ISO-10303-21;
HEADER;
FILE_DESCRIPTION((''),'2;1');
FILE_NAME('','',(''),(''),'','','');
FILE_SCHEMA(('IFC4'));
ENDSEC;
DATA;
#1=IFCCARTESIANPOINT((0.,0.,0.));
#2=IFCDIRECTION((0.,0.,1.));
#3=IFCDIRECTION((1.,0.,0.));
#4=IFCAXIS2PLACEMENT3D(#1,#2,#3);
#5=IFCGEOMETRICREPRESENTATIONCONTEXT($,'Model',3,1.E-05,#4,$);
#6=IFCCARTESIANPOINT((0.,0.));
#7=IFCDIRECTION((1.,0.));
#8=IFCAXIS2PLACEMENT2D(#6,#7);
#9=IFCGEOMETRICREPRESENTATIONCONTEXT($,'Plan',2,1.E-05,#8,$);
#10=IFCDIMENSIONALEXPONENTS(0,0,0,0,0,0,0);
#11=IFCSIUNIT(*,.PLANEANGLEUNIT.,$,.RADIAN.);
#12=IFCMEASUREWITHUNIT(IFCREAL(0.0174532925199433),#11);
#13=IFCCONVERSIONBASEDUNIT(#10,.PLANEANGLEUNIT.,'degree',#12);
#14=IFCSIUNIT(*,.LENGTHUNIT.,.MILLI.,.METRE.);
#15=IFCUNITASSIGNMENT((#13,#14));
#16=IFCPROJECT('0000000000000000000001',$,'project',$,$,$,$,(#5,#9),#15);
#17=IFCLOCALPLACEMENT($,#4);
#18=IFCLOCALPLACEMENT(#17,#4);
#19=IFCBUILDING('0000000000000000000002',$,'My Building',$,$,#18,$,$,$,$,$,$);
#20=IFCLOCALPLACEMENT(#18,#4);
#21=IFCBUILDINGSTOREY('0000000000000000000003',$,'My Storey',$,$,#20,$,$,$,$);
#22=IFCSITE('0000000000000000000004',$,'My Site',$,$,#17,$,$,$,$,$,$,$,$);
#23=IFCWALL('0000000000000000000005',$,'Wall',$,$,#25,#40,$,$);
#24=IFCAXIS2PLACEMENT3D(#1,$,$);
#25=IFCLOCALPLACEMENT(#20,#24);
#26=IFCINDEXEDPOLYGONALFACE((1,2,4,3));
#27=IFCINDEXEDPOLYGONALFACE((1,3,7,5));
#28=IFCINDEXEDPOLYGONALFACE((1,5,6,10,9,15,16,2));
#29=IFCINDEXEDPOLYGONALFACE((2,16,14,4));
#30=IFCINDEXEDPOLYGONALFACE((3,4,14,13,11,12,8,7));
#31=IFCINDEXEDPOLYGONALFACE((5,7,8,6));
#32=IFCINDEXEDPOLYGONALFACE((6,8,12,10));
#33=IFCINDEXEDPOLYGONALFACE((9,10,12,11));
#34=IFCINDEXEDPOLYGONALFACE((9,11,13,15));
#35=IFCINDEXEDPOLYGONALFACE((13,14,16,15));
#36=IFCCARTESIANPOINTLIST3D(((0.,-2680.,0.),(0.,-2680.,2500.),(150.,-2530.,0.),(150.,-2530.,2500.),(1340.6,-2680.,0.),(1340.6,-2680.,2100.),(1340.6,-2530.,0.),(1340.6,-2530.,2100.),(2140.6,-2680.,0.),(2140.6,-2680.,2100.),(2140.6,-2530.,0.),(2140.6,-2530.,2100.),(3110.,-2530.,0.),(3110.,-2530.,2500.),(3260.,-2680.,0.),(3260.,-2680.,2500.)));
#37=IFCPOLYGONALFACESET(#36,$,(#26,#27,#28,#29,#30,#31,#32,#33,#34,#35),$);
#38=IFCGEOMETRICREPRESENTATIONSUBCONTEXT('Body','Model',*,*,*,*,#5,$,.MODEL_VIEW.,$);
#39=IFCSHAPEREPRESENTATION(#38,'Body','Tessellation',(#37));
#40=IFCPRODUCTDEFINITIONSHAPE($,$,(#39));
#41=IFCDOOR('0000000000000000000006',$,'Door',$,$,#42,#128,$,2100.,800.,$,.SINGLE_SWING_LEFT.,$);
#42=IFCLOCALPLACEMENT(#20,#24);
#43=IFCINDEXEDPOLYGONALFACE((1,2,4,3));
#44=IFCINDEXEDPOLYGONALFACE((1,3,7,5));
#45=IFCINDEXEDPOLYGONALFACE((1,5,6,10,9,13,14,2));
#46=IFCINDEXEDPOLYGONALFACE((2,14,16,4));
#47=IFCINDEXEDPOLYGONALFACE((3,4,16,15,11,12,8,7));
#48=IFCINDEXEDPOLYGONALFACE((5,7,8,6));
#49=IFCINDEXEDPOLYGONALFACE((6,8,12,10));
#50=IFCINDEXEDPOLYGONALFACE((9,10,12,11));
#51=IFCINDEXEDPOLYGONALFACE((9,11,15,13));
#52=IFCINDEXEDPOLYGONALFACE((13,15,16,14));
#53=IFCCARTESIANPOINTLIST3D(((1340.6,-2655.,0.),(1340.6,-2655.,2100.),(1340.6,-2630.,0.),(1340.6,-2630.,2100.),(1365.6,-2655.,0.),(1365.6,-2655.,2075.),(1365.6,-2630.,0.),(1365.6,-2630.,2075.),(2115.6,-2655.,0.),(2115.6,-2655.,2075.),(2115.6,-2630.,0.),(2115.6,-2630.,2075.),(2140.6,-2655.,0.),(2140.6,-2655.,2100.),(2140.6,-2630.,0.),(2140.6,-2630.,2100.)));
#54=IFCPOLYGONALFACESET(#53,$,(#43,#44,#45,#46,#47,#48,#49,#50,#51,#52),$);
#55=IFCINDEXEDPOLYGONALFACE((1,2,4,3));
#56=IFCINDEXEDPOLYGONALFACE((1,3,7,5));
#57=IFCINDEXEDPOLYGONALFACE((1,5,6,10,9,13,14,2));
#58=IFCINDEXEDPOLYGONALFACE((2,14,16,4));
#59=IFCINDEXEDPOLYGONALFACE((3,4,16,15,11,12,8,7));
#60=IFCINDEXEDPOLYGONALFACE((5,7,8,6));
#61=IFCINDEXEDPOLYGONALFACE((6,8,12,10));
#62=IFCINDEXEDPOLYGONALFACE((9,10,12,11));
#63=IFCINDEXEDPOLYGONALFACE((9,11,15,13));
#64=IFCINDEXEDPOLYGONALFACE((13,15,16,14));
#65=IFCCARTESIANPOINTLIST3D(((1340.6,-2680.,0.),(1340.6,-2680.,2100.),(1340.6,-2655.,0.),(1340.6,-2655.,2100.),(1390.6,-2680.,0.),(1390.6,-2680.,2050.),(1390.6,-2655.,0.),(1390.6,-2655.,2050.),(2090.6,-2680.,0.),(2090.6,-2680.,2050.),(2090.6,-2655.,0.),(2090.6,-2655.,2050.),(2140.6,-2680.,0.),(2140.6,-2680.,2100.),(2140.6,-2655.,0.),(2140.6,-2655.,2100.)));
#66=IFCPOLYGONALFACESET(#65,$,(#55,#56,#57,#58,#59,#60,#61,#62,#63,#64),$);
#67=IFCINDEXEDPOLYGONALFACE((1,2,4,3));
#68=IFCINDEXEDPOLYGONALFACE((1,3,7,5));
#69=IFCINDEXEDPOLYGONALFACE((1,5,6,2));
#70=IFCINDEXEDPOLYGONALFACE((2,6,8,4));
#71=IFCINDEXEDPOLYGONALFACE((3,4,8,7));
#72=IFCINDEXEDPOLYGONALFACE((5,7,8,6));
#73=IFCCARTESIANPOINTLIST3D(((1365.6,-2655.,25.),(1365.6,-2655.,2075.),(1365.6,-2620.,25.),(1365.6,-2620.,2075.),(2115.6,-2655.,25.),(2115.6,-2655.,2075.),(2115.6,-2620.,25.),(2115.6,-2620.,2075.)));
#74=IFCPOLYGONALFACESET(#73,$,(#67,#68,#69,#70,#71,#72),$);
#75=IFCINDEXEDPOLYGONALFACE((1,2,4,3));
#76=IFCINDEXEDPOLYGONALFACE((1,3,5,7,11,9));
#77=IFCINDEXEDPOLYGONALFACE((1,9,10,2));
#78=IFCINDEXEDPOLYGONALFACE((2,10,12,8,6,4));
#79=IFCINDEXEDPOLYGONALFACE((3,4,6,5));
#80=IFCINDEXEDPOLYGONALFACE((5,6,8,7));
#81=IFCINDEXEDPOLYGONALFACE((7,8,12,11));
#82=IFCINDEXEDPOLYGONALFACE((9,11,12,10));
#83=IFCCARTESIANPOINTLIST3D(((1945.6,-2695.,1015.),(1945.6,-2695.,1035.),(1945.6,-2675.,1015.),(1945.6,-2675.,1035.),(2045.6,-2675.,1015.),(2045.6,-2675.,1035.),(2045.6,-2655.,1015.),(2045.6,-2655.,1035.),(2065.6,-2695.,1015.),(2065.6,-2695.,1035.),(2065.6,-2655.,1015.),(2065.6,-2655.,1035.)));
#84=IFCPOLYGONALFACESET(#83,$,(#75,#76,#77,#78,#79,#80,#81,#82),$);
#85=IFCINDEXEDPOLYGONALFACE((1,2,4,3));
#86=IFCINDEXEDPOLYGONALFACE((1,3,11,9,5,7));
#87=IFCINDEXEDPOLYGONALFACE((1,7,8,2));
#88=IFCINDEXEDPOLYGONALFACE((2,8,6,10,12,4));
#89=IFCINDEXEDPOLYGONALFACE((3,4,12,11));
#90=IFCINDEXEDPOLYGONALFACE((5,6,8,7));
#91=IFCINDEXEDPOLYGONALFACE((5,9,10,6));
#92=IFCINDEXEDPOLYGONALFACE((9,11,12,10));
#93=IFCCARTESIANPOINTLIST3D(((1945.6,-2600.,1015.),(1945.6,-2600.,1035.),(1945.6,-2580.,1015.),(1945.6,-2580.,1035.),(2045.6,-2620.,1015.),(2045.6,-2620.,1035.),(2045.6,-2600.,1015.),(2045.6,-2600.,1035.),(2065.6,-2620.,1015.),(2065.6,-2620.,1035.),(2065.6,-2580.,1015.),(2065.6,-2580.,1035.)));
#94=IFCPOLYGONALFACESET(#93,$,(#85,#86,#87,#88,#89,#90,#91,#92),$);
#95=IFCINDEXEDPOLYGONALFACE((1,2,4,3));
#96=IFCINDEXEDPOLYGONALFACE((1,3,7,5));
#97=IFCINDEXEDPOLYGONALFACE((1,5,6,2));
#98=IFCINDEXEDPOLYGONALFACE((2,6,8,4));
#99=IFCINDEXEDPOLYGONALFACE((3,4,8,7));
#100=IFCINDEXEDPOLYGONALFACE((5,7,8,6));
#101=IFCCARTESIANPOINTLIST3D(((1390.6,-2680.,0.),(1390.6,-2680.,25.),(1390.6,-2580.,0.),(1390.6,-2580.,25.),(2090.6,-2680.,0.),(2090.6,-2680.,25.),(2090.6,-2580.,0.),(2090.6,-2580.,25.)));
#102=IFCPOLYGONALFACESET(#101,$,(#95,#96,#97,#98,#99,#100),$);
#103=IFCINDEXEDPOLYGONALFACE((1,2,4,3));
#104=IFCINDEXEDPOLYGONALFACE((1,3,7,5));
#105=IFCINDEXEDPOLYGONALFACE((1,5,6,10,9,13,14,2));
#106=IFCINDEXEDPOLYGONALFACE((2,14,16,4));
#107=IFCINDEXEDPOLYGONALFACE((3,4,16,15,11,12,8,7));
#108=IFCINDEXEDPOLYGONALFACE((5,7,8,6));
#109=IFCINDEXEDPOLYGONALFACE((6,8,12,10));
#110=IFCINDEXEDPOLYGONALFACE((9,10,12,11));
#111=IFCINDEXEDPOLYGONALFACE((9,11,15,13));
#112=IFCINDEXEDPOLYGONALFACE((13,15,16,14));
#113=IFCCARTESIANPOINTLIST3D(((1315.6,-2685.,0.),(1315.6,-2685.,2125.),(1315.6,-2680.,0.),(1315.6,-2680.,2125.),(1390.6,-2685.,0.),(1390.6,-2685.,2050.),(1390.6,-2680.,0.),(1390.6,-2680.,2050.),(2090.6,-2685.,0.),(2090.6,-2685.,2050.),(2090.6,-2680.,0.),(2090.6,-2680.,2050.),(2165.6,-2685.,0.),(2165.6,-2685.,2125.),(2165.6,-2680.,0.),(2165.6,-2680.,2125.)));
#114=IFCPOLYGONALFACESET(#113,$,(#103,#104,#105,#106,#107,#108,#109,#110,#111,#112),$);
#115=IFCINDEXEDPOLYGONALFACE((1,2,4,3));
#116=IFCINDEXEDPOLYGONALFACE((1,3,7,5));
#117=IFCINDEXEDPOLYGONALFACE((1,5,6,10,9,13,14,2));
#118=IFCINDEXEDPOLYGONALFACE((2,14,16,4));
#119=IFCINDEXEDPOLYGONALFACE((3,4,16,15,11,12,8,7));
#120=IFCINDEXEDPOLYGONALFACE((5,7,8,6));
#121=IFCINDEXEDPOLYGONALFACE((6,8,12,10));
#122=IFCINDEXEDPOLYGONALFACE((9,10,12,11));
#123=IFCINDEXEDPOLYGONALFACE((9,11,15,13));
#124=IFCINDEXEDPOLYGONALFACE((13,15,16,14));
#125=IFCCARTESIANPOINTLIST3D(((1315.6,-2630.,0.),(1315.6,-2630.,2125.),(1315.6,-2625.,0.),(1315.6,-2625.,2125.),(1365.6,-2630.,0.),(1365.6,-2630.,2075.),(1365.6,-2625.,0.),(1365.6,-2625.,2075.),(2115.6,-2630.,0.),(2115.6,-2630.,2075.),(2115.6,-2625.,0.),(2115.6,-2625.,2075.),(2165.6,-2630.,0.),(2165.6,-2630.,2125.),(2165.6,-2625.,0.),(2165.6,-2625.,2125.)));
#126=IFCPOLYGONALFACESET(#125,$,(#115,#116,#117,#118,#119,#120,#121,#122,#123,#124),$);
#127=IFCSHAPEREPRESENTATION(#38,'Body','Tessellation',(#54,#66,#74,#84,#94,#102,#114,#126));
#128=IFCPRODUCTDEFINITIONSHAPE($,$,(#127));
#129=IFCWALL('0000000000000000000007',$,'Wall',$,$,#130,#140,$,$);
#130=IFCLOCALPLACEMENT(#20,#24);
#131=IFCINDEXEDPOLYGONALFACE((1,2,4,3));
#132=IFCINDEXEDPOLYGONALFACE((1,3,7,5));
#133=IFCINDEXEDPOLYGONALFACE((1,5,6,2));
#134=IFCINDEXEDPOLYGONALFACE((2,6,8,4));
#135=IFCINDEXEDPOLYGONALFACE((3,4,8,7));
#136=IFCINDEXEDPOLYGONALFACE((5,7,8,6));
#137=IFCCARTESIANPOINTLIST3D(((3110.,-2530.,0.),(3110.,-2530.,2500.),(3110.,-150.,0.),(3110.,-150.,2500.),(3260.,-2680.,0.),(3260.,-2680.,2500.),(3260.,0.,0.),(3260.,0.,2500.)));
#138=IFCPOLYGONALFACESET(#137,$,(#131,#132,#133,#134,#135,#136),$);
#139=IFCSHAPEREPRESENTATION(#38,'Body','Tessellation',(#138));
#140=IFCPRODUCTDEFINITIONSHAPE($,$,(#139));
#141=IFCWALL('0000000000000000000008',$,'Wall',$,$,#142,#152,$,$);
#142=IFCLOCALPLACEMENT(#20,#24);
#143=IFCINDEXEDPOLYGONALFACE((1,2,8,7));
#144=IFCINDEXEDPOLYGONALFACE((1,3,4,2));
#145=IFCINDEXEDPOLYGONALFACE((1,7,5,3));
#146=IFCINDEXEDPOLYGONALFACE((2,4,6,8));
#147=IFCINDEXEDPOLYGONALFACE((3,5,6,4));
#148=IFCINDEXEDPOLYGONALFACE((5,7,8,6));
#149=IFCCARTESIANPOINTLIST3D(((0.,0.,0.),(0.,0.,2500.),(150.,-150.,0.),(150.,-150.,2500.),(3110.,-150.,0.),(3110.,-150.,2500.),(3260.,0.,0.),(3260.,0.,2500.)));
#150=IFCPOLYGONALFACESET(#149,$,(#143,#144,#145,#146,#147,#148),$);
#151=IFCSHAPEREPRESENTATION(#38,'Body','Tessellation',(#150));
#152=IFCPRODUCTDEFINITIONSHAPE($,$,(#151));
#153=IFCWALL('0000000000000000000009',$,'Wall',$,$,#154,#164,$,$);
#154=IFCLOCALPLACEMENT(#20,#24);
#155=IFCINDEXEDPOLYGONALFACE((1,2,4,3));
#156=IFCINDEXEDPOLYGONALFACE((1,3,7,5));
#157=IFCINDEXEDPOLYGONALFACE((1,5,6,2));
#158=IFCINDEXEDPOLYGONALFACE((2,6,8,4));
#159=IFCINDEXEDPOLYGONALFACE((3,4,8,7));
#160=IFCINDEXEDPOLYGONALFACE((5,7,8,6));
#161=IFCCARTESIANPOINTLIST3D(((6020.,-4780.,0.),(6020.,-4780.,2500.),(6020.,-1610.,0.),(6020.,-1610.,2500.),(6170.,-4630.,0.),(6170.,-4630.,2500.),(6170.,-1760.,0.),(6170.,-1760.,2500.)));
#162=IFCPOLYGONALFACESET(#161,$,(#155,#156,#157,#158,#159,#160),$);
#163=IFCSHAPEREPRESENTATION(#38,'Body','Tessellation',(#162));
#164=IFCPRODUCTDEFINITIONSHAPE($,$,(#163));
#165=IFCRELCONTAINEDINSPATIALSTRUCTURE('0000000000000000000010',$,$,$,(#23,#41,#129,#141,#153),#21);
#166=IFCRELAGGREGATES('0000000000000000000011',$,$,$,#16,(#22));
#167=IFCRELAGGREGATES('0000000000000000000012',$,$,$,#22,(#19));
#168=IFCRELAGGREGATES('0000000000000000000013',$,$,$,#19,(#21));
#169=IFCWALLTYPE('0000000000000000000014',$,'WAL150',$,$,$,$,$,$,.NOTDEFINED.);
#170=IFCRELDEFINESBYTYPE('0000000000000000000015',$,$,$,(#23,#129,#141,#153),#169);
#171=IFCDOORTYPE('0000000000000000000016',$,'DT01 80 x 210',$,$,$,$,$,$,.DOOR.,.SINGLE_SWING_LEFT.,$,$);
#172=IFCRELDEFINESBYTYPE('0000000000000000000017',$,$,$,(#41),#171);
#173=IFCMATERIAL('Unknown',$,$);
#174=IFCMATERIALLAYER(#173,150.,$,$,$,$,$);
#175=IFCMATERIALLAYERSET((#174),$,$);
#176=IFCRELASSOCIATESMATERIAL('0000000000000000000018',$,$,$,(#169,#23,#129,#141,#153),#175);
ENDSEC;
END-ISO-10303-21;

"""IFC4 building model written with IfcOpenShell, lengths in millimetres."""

from ifc_helpers import new_model, entity, si_unit, converted_unit, frame, origin_with_axes, origin_2d_with_axis, place, context, subcontext, project, spatial, line, indexed_curve, outline, extrude, shape, source, transform, mapped, material, layer, layer_set, layer_usage, type_object, type_shapes, element, fill, save


model = new_model("IFC4")

# Units and contexts
model_context = context("Model", 3, precision=1e-05, world=origin_with_axes())
plan_context = context("Plan", 2, precision=1e-05, world=origin_2d_with_axis())
body_context_1 = subcontext(model_context, "Body", "Model", "MODEL_VIEW")
body_context_2 = subcontext(plan_context, "Body", "Plan", "PLAN_VIEW")
ifc_project = project(units=[converted_unit("PLANEANGLEUNIT", "degree", entity("IfcReal", 0.0174532925199433), si_unit("PLANEANGLEUNIT", "RADIAN"), dimensions=[0, 0, 0, 0, 0, 0, 0]), si_unit("LENGTHUNIT", "METRE", prefix="MILLI")], contexts=[model_context, plan_context])

# Site, building, storey
site_placement = place(None, origin_with_axes())
site = spatial("IfcSite", under=ifc_project, at=site_placement, Name="My Site")
building_placement = place(site_placement, origin_with_axes())
building = spatial("IfcBuilding", under=site, at=building_placement, Name="My Building")
storey_placement = place(building_placement, origin_with_axes())
storey = spatial("IfcBuildingStorey", under=building, at=storey_placement, Name="My Storey")

# Shared definitions
ifc_material = material(Name="Unknown")

# Shared definitions
ifc_layer_1 = layer(ifc_material, 150.0)
ifc_layer_set_1 = layer_set([ifc_layer_1])
wall_type_1 = type_object("IfcWallType", Name="WAL150", PredefinedType="NOTDEFINED", material=ifc_layer_set_1)

# Wall, opening, door
ifc_layer_usage_1 = layer_usage(ifc_layer_set_1, "AXIS2", "POSITIVE", 0.0)
wall_1_placement = place(storey_placement, frame((0.0, -2680.0, 0.0), z_axis=(0.0, 0.0, 1.0), x_axis=(1.0, 0.0, 0.0)))
wall_1 = element("IfcWall", 1, at=wall_1_placement, inside=storey, type_object=wall_type_1, material=ifc_layer_usage_1, Name="Wall", context=body_context_1, shape_type="SweptSolid", body=[
    extrude(outline(indexed_curve([(0.0, 0.0), (150.0, 150.0), (3110.0, 150.0), (3260.0, 0.0)], segments=[line(1, 2, 3, 4, 1)])), origin_with_axes(), (0.0, 0.0, 1.0), 2500.0),
])
shared_shape_1 = source(origin_with_axes(), body_context_1, "Body", "SweptSolid", [
    extrude(outline(indexed_curve([(0.0, 0.0), (800.0, 0.0), (800.0, 2100.0), (0.0, 2100.0)], segments=[line(1, 2, 3, 4, 1)])), frame((0.0, -600.0, 0.0), z_axis=(0.0, -1.0, 0.0), x_axis=(1.0, 0.0, 0.0)), (0.0, 0.0, -1.0), 1200.0),
])
opening_1_placement = place(wall_1_placement, frame((1340.6, 0.0, 0.0), z_axis=(0.0, 0.0, 1.0), x_axis=(1.0, 0.0, 0.0)))
opening_1 = element("IfcOpeningElement", 2, at=opening_1_placement, cuts=wall_1, PredefinedType="OPENING", context=body_context_1, shape_type="MappedRepresentation", body=[
    mapped(shared_shape_1, transform((0.0, 0.0, 0.0), x_axis=(1.0, 0.0, 0.0), y_axis=(0.0, 1.0, 0.0), z_axis=(0.0, 0.0, 1.0), scale=1.0)),
])
door_type = type_object("IfcDoorType", Name="DT01 80 x 210", OperationType="SINGLE_SWING_LEFT", PredefinedType="DOOR")
shared_shape_2 = source(origin_with_axes(), body_context_1, "Body", "SweptSolid", [
    extrude(outline(indexed_curve([(0.0, 0.0), (0.0, 2100.0), (800.0, 2100.0), (800.0, 0.0), (775.0, 0.0), (775.0, 2075.0), (25.0, 2075.0), (25.0, 0.0)], segments=[line(1, 2, 3, 4, 5, 6, 7, 8, 1)])), frame((0.0, 25.0, 0.0), z_axis=(0.0, -1.0, 0.0), x_axis=(1.0, 0.0, 0.0)), (0.0, 0.0, -1.0), 25.0),
    extrude(outline(indexed_curve([(0.0, 0.0), (0.0, 2100.0), (800.0, 2100.0), (800.0, 0.0), (750.0, 0.0), (750.0, 2050.0), (50.0, 2050.0), (50.0, 0.0)], segments=[line(1, 2, 3, 4, 5, 6, 7, 8, 1)])), frame((0.0, 0.0, 0.0), z_axis=(0.0, -1.0, 0.0), x_axis=(1.0, 0.0, 0.0)), (0.0, 0.0, -1.0), 25.0),
    extrude(outline(indexed_curve([(0.0, 0.0), (750.0, 0.0), (750.0, 35.0), (0.0, 35.0)], segments=[line(1, 2, 3, 4, 1)])), frame((25.0, 25.0, 25.0), z_axis=(0.0, 0.0, 1.0), x_axis=(1.0, 0.0, 0.0)), (0.0, 0.0, 1.0), 2050.0),
    extrude(outline(indexed_curve([(0.0, 0.0), (0.0, -40.0), (-120.0, -40.0), (-120.0, -20.0), (-20.0, -20.0), (-20.0, 0.0)], segments=[line(1, 2, 3, 4, 5, 6, 1)])), frame((725.0, 25.0, 1015.0), z_axis=(0.0, 0.0, 1.0), x_axis=(1.0, 0.0, 0.0)), (0.0, 0.0, 1.0), 20.0),
    extrude(outline(indexed_curve([(0.0, 0.0), (0.0, 40.0), (-120.0, 40.0), (-120.0, 20.0), (-20.0, 20.0), (-20.0, 0.0)], segments=[line(1, 2, 3, 4, 5, 6, 1)])), frame((725.0, 60.0, 1015.0), z_axis=(0.0, 0.0, 1.0), x_axis=(1.0, 0.0, 0.0)), (0.0, 0.0, 1.0), 20.0),
    extrude(outline(indexed_curve([(0.0, 0.0), (700.0, 0.0), (700.0, 100.0), (0.0, 100.0), (0.0, 0.0)])), frame((50.0, 0.0, 0.0), z_axis=(0.0, 0.0, 1.0), x_axis=(1.0, 0.0, 0.0)), (0.0, 0.0, 1.0), 25.0),
    extrude(outline(indexed_curve([(75.0, 0.0), (75.0, 2050.0), (775.0, 2050.0), (775.0, 0.0), (850.0, 0.0), (850.0, 2125.0), (0.0, 2125.0), (0.0, 0.0), (75.0, 0.0)])), frame((-25.0, -5.0, 0.0), z_axis=(0.0, -1.0, 0.0), x_axis=(1.0, 0.0, 0.0)), (0.0, 0.0, -1.0), 5.0),
    extrude(outline(indexed_curve([(50.0, 0.0), (50.0, 2075.0), (800.0, 2075.0), (800.0, 0.0), (850.0, 0.0), (850.0, 2125.0), (0.0, 2125.0), (0.0, 0.0), (50.0, 0.0)])), frame((-25.0, 50.0, 0.0), z_axis=(0.0, -1.0, 0.0), x_axis=(1.0, 0.0, 0.0)), (0.0, 0.0, -1.0), 5.0),
])
shared_shape_3 = source(origin_with_axes(), body_context_2, "Body", "Curve2D", [
    entity("IfcIndexedPolyCurve", entity("IfcCartesianPointList2D", [[0.0, 0.0], [0.0, 50.0], [25.0, 50.0], [25.0, 25.0], [50.0, 25.0], [50.0, 0.0]]), [entity("IfcLineIndex", [1, 2, 3, 4, 5, 6, 1])]),
    entity("IfcIndexedPolyCurve", entity("IfcCartesianPointList2D", [[800.0, 0.0], [800.0, 50.0], [775.0, 50.0], [775.0, 25.0], [750.0, 25.0], [750.0, 0.0]]), [entity("IfcLineIndex", [1, 2, 3, 4, 5, 6, 1])]),
    entity("IfcTrimmedCurve", entity("IfcEllipse", entity("IfcAxis2Placement2D", entity("IfcCartesianPoint", [60.0, 50.0]), entity("IfcDirection", [1.0, 0.0])), 715.0, 750.0), [entity("IfcCartesianPoint", [775.0, 50.0])], [entity("IfcCartesianPoint", [60.0, 800.0])], True, "CARTESIAN"),
    entity("IfcIndexedPolyCurve", entity("IfcCartesianPointList2D", [[25.0, 50.0], [60.0, 50.0], [60.0, 800.0], [25.0, 800.0]]), [entity("IfcLineIndex", [1, 2, 3, 4, 1])]),
])
type_shapes(door_type, [shared_shape_2, shared_shape_3])
door_1_placement = place(opening_1_placement, origin_with_axes())
door_1 = element("IfcDoor", 3, at=door_1_placement, inside=storey, type_object=door_type, Name="Door", OperationType="SINGLE_SWING_LEFT", OverallHeight=2100.0, OverallWidth=800.0, shapes=[
    shape(body_context_1, "Body", "MappedRepresentation", [mapped(shared_shape_2, transform((0.0, 0.0, 0.0), x_axis=(1.0, 0.0, 0.0), y_axis=(0.0, 1.0, 0.0), z_axis=(0.0, 0.0, 1.0), scale=1.0))]),
    shape(body_context_2, "Body", "MappedRepresentation", [mapped(shared_shape_3, transform((0.0, 0.0, 0.0), x_axis=(1.0, 0.0, 0.0), y_axis=(0.0, 1.0, 0.0), z_axis=(0.0, 0.0, 1.0), scale=1.0))]),
])
fill(opening_1, door_1)

# Walls
ifc_layer_usage_2 = layer_usage(ifc_layer_set_1, "AXIS2", "POSITIVE", 0.0)
wall_2_placement = place(storey_placement, frame((3260.0, -2680.0, 0.0), z_axis=(0.0, 0.0, 1.0), x_axis=(0.0, 1.0, 0.0)))
element("IfcWall", 4, at=wall_2_placement, inside=storey, type_object=wall_type_1, material=ifc_layer_usage_2, Name="Wall", context=body_context_1, shape_type="SweptSolid", body=[
    extrude(outline(indexed_curve([(0.0, 0.0), (150.0, 150.0), (2530.0, 150.0), (2680.0, 0.0)], segments=[line(1, 2, 3, 4, 1)])), origin_with_axes(), (0.0, 0.0, 1.0), 2500.0),
])
ifc_layer_usage_3 = layer_usage(ifc_layer_set_1, "AXIS2", "POSITIVE", 0.0)
wall_3_placement = place(storey_placement, frame((3260.0, 0.0, 0.0), z_axis=(0.0, 0.0, 1.0), x_axis=(-1.0, 0.0, 0.0)))
element("IfcWall", 5, at=wall_3_placement, inside=storey, type_object=wall_type_1, material=ifc_layer_usage_3, Name="Wall", context=body_context_1, shape_type="SweptSolid", body=[
    extrude(outline(indexed_curve([(0.0, 0.0), (150.0, 150.0), (3110.0, 150.0), (3260.0, 0.0)], segments=[line(1, 2, 3, 4, 1)])), origin_with_axes(), (0.0, 0.0, 1.0), 2500.0),
])
ifc_layer_usage_4 = layer_usage(ifc_layer_set_1, "AXIS2", "POSITIVE", 0.0)
wall_4_placement = place(storey_placement, frame((6020.0, -1610.0, 0.0), z_axis=(0.0, 0.0, 1.0), x_axis=(0.0, -1.0, 0.0)))
element("IfcWall", 6, at=wall_4_placement, inside=storey, type_object=wall_type_1, material=ifc_layer_usage_4, Name="Wall", context=body_context_1, shape_type="SweptSolid", body=[
    extrude(outline(indexed_curve([(0.0, 0.0), (150.0, 150.0), (3020.0, 150.0), (3170.0, 0.0)], segments=[line(1, 2, 3, 4, 1)])), origin_with_axes(), (0.0, 0.0, 1.0), 2500.0),
])

save(model, "model.ifc")
